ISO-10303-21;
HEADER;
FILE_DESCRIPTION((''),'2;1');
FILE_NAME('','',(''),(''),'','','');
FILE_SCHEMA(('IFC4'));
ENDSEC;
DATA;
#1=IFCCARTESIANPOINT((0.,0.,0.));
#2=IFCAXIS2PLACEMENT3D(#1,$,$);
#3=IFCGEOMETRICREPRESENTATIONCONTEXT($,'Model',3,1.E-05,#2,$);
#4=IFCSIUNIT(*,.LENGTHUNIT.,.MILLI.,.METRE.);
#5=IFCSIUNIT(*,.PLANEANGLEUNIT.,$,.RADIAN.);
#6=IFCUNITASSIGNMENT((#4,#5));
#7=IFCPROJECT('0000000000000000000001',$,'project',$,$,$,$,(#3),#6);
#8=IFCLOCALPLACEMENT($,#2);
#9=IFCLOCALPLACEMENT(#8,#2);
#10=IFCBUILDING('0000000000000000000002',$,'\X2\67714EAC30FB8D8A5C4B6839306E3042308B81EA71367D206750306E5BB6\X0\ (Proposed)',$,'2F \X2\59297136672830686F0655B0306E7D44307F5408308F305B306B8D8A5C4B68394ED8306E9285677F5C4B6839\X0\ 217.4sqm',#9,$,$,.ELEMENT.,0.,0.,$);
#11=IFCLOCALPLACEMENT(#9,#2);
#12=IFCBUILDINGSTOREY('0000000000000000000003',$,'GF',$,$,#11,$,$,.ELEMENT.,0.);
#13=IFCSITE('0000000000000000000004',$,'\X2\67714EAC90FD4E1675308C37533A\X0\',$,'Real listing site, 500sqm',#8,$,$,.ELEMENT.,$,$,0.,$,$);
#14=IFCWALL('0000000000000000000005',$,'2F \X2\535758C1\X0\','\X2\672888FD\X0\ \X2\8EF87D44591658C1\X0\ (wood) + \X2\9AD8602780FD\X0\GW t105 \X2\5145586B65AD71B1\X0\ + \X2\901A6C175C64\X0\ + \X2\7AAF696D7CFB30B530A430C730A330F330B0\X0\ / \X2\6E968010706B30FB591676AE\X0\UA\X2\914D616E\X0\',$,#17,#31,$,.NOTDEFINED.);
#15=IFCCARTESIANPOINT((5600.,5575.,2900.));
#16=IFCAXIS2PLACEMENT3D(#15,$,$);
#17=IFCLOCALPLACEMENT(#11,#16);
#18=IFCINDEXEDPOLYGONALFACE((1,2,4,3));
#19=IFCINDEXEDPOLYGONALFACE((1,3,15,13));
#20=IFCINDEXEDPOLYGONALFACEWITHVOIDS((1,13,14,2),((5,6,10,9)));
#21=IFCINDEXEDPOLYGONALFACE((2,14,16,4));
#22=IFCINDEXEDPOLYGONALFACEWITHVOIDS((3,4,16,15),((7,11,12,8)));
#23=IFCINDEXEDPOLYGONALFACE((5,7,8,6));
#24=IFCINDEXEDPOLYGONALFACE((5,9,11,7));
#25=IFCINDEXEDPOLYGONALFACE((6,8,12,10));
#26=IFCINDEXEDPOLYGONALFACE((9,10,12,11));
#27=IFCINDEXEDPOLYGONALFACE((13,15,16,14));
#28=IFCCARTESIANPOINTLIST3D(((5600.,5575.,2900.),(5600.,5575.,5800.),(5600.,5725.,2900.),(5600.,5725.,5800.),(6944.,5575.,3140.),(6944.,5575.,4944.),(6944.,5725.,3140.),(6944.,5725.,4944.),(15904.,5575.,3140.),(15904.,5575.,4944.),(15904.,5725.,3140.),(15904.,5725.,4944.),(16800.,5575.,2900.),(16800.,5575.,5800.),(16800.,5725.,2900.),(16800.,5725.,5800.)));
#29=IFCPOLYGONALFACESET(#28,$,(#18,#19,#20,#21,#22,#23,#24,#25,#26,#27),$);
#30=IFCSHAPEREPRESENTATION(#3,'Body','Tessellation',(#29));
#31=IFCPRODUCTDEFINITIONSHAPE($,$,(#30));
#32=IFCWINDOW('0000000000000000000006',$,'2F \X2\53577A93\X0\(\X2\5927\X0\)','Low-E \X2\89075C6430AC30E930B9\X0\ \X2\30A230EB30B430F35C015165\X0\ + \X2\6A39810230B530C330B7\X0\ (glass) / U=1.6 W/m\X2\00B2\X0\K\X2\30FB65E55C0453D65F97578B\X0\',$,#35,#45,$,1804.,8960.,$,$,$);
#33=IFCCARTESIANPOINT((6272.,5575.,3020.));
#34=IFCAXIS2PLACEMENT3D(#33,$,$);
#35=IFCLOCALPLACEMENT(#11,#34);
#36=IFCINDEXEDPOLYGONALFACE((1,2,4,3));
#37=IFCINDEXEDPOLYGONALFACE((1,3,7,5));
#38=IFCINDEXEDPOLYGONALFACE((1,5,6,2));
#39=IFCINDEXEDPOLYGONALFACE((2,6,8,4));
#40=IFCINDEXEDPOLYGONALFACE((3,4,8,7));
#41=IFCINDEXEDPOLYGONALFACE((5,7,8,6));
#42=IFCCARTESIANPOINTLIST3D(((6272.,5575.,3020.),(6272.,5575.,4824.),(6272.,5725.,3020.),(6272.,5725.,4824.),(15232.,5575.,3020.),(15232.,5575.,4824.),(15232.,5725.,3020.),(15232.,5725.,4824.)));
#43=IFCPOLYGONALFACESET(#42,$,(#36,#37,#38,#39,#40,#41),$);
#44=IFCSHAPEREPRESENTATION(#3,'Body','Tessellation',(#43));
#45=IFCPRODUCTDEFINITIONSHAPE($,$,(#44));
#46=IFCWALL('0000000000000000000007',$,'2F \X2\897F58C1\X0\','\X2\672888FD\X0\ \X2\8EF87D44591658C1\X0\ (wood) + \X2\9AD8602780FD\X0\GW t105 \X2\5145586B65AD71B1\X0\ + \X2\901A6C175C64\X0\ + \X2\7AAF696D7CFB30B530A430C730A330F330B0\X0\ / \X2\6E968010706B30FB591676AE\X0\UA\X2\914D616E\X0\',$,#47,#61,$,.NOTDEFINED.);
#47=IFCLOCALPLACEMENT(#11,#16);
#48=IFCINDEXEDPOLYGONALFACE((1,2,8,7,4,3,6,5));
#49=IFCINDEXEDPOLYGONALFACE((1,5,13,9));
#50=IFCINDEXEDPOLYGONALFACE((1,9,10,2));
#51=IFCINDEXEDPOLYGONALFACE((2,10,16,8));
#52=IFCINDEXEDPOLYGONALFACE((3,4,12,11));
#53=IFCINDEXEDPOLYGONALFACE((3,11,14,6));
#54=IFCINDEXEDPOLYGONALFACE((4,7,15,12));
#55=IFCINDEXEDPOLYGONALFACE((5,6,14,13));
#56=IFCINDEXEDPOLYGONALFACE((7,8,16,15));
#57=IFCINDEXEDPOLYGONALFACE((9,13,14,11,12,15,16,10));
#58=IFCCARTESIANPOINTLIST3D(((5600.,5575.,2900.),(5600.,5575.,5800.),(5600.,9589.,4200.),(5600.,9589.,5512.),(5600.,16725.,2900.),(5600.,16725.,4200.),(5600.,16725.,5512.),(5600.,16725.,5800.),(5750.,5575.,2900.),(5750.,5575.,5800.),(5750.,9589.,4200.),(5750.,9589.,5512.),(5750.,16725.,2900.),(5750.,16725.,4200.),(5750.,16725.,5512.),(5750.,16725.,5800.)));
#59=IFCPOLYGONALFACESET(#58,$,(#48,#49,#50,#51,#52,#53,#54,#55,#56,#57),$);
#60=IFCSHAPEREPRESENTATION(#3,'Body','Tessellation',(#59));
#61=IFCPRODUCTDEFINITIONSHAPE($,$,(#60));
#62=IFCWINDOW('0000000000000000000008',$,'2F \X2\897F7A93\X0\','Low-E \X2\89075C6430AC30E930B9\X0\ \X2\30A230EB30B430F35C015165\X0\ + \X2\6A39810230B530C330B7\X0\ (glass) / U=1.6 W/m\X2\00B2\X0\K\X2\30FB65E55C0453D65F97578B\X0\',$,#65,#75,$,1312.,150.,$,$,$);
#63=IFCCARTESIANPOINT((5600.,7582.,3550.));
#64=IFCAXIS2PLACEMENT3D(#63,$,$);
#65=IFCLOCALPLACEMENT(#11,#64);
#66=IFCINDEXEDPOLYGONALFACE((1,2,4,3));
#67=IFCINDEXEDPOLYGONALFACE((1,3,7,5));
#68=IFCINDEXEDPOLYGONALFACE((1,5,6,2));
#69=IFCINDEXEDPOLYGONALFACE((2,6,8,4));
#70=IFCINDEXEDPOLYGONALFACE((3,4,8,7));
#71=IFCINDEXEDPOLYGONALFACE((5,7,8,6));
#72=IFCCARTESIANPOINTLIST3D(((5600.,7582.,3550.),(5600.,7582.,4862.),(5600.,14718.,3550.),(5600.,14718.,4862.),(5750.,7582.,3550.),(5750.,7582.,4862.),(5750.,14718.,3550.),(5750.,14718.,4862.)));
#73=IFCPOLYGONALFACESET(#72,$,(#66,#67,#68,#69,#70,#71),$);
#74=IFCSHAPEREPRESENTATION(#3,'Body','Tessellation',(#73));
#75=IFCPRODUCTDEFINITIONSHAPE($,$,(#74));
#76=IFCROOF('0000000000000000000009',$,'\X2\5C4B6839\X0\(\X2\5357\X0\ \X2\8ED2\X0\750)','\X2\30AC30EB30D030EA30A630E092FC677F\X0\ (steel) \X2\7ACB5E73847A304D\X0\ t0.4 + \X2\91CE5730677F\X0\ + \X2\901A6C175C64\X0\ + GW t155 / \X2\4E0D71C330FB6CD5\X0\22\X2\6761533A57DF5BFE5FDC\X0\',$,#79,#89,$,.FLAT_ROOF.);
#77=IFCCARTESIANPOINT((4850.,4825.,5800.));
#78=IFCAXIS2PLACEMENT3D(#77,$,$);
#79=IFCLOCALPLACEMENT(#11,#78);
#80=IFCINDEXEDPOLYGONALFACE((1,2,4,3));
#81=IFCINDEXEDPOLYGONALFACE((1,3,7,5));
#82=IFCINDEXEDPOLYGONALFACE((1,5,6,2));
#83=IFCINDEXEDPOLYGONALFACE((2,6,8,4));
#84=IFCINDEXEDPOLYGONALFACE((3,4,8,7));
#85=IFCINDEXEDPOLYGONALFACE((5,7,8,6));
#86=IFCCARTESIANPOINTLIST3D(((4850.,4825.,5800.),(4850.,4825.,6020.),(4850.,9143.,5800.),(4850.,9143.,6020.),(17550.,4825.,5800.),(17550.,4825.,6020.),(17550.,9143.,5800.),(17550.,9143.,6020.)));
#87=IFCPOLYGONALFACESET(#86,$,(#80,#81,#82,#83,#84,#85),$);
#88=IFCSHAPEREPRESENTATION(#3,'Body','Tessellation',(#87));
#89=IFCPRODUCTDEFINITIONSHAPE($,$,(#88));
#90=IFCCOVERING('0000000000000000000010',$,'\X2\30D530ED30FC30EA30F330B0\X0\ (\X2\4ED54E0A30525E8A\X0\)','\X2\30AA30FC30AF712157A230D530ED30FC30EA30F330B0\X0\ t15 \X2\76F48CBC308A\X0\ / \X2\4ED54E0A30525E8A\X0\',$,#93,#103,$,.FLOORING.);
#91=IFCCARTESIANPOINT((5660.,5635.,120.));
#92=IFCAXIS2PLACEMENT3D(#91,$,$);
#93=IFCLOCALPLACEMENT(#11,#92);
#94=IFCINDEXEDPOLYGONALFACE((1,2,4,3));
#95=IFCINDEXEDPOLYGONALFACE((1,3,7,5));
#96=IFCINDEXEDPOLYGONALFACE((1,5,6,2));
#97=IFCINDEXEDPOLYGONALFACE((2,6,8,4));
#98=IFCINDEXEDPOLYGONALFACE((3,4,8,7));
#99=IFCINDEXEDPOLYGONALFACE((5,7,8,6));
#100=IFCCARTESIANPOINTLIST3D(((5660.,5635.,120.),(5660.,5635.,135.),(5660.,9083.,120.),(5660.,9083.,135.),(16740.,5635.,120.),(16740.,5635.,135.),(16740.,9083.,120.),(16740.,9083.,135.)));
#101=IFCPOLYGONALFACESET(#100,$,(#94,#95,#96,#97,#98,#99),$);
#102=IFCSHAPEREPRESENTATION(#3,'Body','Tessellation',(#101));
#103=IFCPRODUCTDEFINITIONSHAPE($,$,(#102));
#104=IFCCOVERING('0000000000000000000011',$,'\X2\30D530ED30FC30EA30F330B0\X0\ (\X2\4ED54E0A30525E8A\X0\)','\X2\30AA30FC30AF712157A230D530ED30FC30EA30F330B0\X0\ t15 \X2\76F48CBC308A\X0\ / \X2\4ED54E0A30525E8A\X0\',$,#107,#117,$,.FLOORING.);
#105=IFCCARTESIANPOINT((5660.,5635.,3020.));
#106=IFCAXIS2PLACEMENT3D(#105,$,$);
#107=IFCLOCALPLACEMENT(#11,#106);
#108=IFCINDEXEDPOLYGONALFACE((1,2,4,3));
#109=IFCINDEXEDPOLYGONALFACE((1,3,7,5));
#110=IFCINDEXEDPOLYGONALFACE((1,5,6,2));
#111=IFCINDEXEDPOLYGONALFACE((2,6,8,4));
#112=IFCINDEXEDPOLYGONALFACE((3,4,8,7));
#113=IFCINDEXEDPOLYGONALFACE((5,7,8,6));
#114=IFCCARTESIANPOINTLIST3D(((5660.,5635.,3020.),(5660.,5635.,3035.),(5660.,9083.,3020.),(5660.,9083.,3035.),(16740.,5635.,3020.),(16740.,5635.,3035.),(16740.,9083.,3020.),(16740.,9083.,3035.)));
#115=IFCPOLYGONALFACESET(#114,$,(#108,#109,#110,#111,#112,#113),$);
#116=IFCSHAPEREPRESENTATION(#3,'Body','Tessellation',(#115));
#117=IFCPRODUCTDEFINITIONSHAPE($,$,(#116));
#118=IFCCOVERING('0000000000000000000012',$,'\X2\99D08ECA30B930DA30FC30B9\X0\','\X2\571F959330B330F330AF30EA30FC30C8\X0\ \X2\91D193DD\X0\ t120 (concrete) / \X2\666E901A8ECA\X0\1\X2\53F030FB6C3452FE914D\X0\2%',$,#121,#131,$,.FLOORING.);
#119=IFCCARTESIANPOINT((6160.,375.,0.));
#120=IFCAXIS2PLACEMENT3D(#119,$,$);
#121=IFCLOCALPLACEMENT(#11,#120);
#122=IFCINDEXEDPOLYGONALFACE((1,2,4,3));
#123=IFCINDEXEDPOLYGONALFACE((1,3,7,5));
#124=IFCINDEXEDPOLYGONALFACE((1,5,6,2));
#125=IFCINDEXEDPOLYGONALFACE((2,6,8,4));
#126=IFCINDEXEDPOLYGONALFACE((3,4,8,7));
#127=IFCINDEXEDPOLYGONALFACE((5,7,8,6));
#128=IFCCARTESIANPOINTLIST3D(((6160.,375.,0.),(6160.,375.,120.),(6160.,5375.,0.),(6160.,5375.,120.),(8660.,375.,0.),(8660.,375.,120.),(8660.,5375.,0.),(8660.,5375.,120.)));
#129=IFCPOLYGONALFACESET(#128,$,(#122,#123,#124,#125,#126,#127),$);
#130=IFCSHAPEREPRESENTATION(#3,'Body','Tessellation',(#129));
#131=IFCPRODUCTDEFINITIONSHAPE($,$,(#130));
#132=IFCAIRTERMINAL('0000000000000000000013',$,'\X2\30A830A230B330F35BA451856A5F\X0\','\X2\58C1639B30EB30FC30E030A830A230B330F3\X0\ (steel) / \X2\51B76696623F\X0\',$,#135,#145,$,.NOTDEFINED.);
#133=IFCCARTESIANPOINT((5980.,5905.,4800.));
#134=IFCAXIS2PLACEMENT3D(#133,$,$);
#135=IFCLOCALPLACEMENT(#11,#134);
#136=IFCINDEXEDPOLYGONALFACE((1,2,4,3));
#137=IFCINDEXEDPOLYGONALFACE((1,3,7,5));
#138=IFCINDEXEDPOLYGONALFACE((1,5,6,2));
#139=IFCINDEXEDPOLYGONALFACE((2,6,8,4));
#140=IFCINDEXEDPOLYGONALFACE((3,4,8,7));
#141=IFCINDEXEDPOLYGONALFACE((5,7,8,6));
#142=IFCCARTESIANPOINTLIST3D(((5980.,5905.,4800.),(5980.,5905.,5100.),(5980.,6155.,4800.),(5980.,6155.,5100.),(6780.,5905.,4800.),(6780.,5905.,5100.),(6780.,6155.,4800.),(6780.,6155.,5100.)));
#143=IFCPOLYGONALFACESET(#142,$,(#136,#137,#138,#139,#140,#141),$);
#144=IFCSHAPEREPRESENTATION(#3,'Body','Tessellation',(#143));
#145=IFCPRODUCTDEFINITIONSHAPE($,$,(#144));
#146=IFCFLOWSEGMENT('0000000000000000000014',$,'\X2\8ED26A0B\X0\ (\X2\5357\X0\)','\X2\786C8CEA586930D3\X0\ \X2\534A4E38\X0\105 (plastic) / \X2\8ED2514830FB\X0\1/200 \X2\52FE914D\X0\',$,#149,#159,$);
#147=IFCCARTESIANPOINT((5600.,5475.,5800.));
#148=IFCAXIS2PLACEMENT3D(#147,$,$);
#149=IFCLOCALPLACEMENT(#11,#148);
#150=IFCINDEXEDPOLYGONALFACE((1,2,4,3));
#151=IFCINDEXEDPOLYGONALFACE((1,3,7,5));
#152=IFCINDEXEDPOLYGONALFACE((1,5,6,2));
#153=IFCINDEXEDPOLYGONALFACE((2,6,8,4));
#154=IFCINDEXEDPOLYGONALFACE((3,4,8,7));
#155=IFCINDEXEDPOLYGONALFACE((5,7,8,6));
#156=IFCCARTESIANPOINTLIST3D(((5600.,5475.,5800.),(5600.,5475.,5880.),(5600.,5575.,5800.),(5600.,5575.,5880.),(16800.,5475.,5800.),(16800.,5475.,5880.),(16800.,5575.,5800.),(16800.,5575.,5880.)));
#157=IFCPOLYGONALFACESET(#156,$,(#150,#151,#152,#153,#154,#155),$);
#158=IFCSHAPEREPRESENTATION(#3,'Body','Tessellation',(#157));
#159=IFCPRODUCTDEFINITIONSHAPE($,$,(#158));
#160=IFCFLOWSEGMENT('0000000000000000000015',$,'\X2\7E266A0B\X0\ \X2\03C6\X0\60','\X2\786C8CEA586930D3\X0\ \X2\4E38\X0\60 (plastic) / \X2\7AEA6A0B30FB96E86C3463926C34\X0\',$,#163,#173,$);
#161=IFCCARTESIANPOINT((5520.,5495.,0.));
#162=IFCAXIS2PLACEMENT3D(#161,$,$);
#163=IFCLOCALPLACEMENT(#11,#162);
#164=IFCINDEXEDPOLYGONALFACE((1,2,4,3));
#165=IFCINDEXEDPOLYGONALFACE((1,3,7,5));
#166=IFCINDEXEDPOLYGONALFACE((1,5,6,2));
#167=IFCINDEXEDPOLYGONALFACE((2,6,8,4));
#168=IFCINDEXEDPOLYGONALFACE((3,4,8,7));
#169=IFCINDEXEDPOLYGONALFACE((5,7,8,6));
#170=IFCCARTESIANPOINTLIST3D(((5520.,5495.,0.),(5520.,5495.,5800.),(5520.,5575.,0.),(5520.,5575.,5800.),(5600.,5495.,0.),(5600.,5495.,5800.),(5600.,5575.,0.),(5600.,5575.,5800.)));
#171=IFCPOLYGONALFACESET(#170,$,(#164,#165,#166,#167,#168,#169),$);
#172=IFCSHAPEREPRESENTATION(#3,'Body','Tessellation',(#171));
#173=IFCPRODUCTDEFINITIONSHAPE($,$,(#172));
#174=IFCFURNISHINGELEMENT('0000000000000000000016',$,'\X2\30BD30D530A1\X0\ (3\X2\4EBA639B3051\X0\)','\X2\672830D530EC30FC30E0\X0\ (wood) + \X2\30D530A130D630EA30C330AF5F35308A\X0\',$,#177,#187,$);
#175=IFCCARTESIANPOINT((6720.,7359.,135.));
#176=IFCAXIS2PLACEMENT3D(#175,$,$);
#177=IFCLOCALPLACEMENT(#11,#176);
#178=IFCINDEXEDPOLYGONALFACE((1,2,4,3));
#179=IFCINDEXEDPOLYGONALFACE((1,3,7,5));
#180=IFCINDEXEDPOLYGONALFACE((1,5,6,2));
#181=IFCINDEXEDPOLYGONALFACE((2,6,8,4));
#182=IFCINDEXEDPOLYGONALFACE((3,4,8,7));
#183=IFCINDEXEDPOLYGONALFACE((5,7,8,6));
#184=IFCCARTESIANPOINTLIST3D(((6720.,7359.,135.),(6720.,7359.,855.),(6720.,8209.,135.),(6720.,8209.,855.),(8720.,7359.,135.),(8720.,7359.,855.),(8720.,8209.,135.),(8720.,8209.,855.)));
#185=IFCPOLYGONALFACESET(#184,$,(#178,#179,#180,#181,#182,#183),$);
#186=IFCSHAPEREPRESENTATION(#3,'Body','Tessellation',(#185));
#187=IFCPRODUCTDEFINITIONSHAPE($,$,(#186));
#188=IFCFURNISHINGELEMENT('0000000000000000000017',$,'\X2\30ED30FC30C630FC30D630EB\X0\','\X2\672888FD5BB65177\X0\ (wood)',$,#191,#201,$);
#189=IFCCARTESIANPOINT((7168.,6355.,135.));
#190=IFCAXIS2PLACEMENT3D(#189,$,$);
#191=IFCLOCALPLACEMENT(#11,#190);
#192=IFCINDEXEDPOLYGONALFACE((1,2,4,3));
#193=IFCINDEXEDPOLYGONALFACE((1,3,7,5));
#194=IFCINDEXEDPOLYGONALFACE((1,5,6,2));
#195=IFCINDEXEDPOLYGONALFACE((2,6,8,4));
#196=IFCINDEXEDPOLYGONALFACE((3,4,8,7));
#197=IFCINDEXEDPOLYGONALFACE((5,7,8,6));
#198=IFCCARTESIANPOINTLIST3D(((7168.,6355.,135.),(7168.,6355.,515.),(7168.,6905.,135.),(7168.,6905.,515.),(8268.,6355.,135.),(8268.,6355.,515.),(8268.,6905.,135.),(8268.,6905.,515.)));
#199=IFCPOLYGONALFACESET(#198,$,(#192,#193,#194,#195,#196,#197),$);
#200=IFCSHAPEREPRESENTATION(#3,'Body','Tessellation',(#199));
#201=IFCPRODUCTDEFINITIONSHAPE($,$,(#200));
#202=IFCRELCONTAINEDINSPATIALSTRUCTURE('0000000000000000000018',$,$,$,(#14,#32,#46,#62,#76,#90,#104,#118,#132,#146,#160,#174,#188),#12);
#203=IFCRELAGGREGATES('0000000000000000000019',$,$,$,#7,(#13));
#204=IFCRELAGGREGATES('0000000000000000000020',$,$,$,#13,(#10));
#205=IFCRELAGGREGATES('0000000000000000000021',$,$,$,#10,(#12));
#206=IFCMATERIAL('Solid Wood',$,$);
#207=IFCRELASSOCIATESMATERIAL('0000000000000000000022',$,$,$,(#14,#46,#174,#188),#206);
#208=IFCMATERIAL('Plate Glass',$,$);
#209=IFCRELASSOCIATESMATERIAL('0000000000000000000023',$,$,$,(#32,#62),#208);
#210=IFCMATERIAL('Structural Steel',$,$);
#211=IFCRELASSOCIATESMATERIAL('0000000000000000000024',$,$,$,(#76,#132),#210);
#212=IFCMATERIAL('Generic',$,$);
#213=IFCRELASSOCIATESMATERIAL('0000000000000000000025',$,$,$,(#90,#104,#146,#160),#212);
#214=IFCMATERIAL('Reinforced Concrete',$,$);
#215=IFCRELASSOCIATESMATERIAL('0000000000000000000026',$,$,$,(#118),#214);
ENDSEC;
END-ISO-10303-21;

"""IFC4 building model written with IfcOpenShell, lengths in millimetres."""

from ifc_helpers import new_model, si_unit, frame, frame_2d, origin, place, context, project, spatial, rectangle, extrude, material, element, fill, save


model = new_model("IFC4")

# Units and contexts
model_context = context("Model", 3, precision=1e-05, world=origin())
ifc_project = project(units=[si_unit("LENGTHUNIT", "METRE", prefix="MILLI"), si_unit("PLANEANGLEUNIT", "RADIAN")], contexts=[model_context])

# Site, building, storey
site_placement = place(None, origin())
site = spatial("IfcSite", under=ifc_project, at=site_placement, Name="東京都世田谷区", ObjectType="Real listing site, 500sqm", CompositionType="ELEMENT", RefElevation=0.0)
building_placement = place(site_placement, origin())
building = spatial("IfcBuilding", under=site, at=building_placement, Name="東京・越屋根のある自然素材の家 (Proposed)", ObjectType="2F 天然木と漆喰の組み合わせに越屋根付の銅板屋根 217.4sqm", CompositionType="ELEMENT", ElevationOfRefHeight=0.0, ElevationOfTerrain=0.0)
storey_placement = place(building_placement, origin())
storey = spatial("IfcBuildingStorey", under=building, at=storey_placement, Name="GF", CompositionType="ELEMENT", Elevation=0.0)

# Shared definitions
ifc_material_1 = material(Name="Solid Wood")

# Shared definitions
ifc_material_2 = material(Name="Reinforced Concrete")

# Shared definitions
ifc_material_3 = material(Name="Plate Glass")

# Walls, openings, windows
wall_1_placement = place(storey_placement, frame((5600.0, 5575.0, 2900.0)))
wall_1 = element("IfcWall", 1, at=wall_1_placement, inside=storey, material=ifc_material_1, Name="2F 南壁", Description="木製 軸組外壁 (wood) + 高性能GW t105 充填断熱 + 通気層 + 窯業系サイディング / 準耐火・外皮UA配慮", PredefinedType="NOTDEFINED", context=model_context, shape_type="SweptSolid", body=[
    extrude(rectangle(XDim=11200.0, YDim=150.0, at=frame_2d((5600.0, 75.0))), frame((5600.0, 5575.0, 2900.0)), (0.0, 0.0, 1.0), 2900.0),
])
opening_1_placement = place(storey_placement, frame((6272.0, 5575.0, 3020.0)))
opening_1 = element("IfcOpeningElement", 2, at=opening_1_placement, cuts=wall_1, PredefinedType="NOTDEFINED", context=model_context, shape_type="SweptSolid", body=[
    extrude(rectangle(XDim=8960.0, YDim=150.0, at=frame_2d((4480.0, 75.0))), frame((6272.0, 5575.0, 3020.0)), (0.0, 0.0, 1.0), 1804.0),
])
window_1_placement = place(storey_placement, frame((6272.0, 5575.0, 3020.0)))
window_1 = element("IfcWindow", 3, at=window_1_placement, inside=storey, material=ifc_material_3, Name="2F 南窓(大)", Description="Low-E 複層ガラス アルゴン封入 + 樹脂サッシ (glass) / U=1.6 W/m²K・日射取得型", OverallHeight=1804.0, OverallWidth=8960.0, context=model_context, shape_type="SweptSolid", body=[
    extrude(rectangle(XDim=8960.0, YDim=150.0, at=frame_2d((4480.0, 75.0))), frame((6272.0, 5575.0, 3020.0)), (0.0, 0.0, 1.0), 1804.0),
])
fill(opening_1, window_1)
wall_2_placement = place(storey_placement, frame((5600.0, 5575.0, 2900.0)))
wall_2 = element("IfcWall", 4, at=wall_2_placement, inside=storey, material=ifc_material_1, Name="2F 西壁", Description="木製 軸組外壁 (wood) + 高性能GW t105 充填断熱 + 通気層 + 窯業系サイディング / 準耐火・外皮UA配慮", PredefinedType="NOTDEFINED", context=model_context, shape_type="SweptSolid", body=[
    extrude(rectangle(XDim=150.0, YDim=11150.0, at=frame_2d((75.0, 5575.0))), frame((5600.0, 5575.0, 2900.0)), (0.0, 0.0, 1.0), 2900.0),
])
opening_2_placement = place(storey_placement, frame((5600.0, 7582.0, 3550.0)))
opening_2 = element("IfcOpeningElement", 5, at=opening_2_placement, cuts=wall_2, PredefinedType="NOTDEFINED", context=model_context, shape_type="SweptSolid", body=[
    extrude(rectangle(XDim=150.0, YDim=7136.0, at=frame_2d((75.0, 3568.0))), frame((5600.0, 7582.0, 3550.0)), (0.0, 0.0, 1.0), 1312.0),
])
window_2_placement = place(storey_placement, frame((5600.0, 7582.0, 3550.0)))
window_2 = element("IfcWindow", 6, at=window_2_placement, inside=storey, material=ifc_material_3, Name="2F 西窓", Description="Low-E 複層ガラス アルゴン封入 + 樹脂サッシ (glass) / U=1.6 W/m²K・日射取得型", OverallHeight=1312.0, OverallWidth=150.0, context=model_context, shape_type="SweptSolid", body=[
    extrude(rectangle(XDim=150.0, YDim=7136.0, at=frame_2d((75.0, 3568.0))), frame((5600.0, 7582.0, 3550.0)), (0.0, 0.0, 1.0), 1312.0),
])
fill(opening_2, window_2)

# Roof
ifc_material_4 = material(Name="Structural Steel")
for number, where, name in (
    (7, (4850.0, 4825.0, 5800.0), "屋根(南 軒750)"),
):
    element("IfcRoof", number, at=place(storey_placement, frame(where)), inside=storey, material=ifc_material_4, Name=name, Description="ガルバリウム鋼板 (steel) 立平葺き t0.4 + 野地板 + 通気層 + GW t155 / 不燃・法22条区域対応", PredefinedType="FLAT_ROOF", context=model_context, shape_type="SweptSolid", body=[
        extrude(rectangle(XDim=12700.0, YDim=4318.0, at=frame_2d((6350.0, 2159.0))), frame((4850.0, 4825.0, 5800.0)), (0.0, 0.0, 1.0), 220.0),
    ])

# Coverings
ifc_material_5 = material(Name="Generic")
covering_1_placement = place(storey_placement, frame((5660.0, 5635.0, 120.0)))
element("IfcCovering", 8, at=covering_1_placement, inside=storey, material=ifc_material_5, Name="フローリング (仕上げ床)", Description="オーク無垢フローリング t15 直貼り / 仕上げ床", PredefinedType="FLOORING", context=model_context, shape_type="SweptSolid", body=[
    extrude(rectangle(XDim=11080.0, YDim=3448.0, at=frame_2d((5540.0, 1724.0))), frame((5660.0, 5635.0, 120.0)), (0.0, 0.0, 1.0), 15.0),
])
covering_2_placement = place(storey_placement, frame((5660.0, 5635.0, 3020.0)))
element("IfcCovering", 9, at=covering_2_placement, inside=storey, material=ifc_material_5, Name="フローリング (仕上げ床)", Description="オーク無垢フローリング t15 直貼り / 仕上げ床", PredefinedType="FLOORING", context=model_context, shape_type="SweptSolid", body=[
    extrude(rectangle(XDim=11080.0, YDim=3448.0, at=frame_2d((5540.0, 1724.0))), frame((5660.0, 5635.0, 3020.0)), (0.0, 0.0, 1.0), 15.0),
])
covering_3_placement = place(storey_placement, frame((6160.0, 375.0, 0.0)))
element("IfcCovering", 10, at=covering_3_placement, inside=storey, material=ifc_material_2, Name="駐車スペース", Description="土間コンクリート 金鏝 t120 (concrete) / 普通車1台・水勾配2%", PredefinedType="FLOORING", context=model_context, shape_type="SweptSolid", body=[
    extrude(rectangle(XDim=2500.0, YDim=5000.0, at=frame_2d((1250.0, 2500.0))), frame((6160.0, 375.0, 0.0)), (0.0, 0.0, 1.0), 120.0),
])

# Air terminal
air_terminal_placement = place(storey_placement, frame((5980.0, 5905.0, 4800.0)))
element("IfcAirTerminal", 11, at=air_terminal_placement, inside=storey, material=ifc_material_4, Name="エアコン室内機", Description="壁掛ルームエアコン (steel) / 冷暖房", PredefinedType="NOTDEFINED", context=model_context, shape_type="SweptSolid", body=[
    extrude(rectangle(XDim=800.0, YDim=250.0, at=frame_2d((400.0, 125.0))), frame((5980.0, 5905.0, 4800.0)), (0.0, 0.0, 1.0), 300.0),
])

# Flow segments
flow_segment_1_placement = place(storey_placement, frame((5600.0, 5475.0, 5800.0)))
element("IfcFlowSegment", 12, at=flow_segment_1_placement, inside=storey, material=ifc_material_5, Name="軒樋 (南)", Description="硬質塩ビ 半丸105 (plastic) / 軒先・1/200 勾配", context=model_context, shape_type="SweptSolid", body=[
    extrude(rectangle(XDim=11200.0, YDim=100.0, at=frame_2d((5600.0, 50.0))), frame((5600.0, 5475.0, 5800.0)), (0.0, 0.0, 1.0), 80.0),
])
flow_segment_2_placement = place(storey_placement, frame((5520.0, 5495.0, 0.0)))
element("IfcFlowSegment", 13, at=flow_segment_2_placement, inside=storey, material=ifc_material_5, Name="縦樋 φ60", Description="硬質塩ビ 丸60 (plastic) / 竪樋・雨水排水", context=model_context, shape_type="SweptSolid", body=[
    extrude(rectangle(XDim=80.0, YDim=80.0, at=frame_2d((40.0, 40.0))), frame((5520.0, 5495.0, 0.0)), (0.0, 0.0, 1.0), 5800.0),
])

# Furnishing elements
furnishing_1_placement = place(storey_placement, frame((6720.0, 7359.0, 135.0)))
element("IfcFurnishingElement", 14, at=furnishing_1_placement, inside=storey, material=ifc_material_1, Name="ソファ (3人掛け)", Description="木フレーム (wood) + ファブリック張り", context=model_context, shape_type="SweptSolid", body=[
    extrude(rectangle(XDim=2000.0, YDim=850.0, at=frame_2d((1000.0, 425.0))), frame((6720.0, 7359.0, 135.0)), (0.0, 0.0, 1.0), 720.0),
])
furnishing_2_placement = place(storey_placement, frame((7168.0, 6355.0, 135.0)))
element("IfcFurnishingElement", 15, at=furnishing_2_placement, inside=storey, material=ifc_material_1, Name="ローテーブル", Description="木製家具 (wood)", context=model_context, shape_type="SweptSolid", body=[
    extrude(rectangle(XDim=1100.0, YDim=550.0, at=frame_2d((550.0, 275.0))), frame((7168.0, 6355.0, 135.0)), (0.0, 0.0, 1.0), 380.0),
])

save(model, "model.ifc")
